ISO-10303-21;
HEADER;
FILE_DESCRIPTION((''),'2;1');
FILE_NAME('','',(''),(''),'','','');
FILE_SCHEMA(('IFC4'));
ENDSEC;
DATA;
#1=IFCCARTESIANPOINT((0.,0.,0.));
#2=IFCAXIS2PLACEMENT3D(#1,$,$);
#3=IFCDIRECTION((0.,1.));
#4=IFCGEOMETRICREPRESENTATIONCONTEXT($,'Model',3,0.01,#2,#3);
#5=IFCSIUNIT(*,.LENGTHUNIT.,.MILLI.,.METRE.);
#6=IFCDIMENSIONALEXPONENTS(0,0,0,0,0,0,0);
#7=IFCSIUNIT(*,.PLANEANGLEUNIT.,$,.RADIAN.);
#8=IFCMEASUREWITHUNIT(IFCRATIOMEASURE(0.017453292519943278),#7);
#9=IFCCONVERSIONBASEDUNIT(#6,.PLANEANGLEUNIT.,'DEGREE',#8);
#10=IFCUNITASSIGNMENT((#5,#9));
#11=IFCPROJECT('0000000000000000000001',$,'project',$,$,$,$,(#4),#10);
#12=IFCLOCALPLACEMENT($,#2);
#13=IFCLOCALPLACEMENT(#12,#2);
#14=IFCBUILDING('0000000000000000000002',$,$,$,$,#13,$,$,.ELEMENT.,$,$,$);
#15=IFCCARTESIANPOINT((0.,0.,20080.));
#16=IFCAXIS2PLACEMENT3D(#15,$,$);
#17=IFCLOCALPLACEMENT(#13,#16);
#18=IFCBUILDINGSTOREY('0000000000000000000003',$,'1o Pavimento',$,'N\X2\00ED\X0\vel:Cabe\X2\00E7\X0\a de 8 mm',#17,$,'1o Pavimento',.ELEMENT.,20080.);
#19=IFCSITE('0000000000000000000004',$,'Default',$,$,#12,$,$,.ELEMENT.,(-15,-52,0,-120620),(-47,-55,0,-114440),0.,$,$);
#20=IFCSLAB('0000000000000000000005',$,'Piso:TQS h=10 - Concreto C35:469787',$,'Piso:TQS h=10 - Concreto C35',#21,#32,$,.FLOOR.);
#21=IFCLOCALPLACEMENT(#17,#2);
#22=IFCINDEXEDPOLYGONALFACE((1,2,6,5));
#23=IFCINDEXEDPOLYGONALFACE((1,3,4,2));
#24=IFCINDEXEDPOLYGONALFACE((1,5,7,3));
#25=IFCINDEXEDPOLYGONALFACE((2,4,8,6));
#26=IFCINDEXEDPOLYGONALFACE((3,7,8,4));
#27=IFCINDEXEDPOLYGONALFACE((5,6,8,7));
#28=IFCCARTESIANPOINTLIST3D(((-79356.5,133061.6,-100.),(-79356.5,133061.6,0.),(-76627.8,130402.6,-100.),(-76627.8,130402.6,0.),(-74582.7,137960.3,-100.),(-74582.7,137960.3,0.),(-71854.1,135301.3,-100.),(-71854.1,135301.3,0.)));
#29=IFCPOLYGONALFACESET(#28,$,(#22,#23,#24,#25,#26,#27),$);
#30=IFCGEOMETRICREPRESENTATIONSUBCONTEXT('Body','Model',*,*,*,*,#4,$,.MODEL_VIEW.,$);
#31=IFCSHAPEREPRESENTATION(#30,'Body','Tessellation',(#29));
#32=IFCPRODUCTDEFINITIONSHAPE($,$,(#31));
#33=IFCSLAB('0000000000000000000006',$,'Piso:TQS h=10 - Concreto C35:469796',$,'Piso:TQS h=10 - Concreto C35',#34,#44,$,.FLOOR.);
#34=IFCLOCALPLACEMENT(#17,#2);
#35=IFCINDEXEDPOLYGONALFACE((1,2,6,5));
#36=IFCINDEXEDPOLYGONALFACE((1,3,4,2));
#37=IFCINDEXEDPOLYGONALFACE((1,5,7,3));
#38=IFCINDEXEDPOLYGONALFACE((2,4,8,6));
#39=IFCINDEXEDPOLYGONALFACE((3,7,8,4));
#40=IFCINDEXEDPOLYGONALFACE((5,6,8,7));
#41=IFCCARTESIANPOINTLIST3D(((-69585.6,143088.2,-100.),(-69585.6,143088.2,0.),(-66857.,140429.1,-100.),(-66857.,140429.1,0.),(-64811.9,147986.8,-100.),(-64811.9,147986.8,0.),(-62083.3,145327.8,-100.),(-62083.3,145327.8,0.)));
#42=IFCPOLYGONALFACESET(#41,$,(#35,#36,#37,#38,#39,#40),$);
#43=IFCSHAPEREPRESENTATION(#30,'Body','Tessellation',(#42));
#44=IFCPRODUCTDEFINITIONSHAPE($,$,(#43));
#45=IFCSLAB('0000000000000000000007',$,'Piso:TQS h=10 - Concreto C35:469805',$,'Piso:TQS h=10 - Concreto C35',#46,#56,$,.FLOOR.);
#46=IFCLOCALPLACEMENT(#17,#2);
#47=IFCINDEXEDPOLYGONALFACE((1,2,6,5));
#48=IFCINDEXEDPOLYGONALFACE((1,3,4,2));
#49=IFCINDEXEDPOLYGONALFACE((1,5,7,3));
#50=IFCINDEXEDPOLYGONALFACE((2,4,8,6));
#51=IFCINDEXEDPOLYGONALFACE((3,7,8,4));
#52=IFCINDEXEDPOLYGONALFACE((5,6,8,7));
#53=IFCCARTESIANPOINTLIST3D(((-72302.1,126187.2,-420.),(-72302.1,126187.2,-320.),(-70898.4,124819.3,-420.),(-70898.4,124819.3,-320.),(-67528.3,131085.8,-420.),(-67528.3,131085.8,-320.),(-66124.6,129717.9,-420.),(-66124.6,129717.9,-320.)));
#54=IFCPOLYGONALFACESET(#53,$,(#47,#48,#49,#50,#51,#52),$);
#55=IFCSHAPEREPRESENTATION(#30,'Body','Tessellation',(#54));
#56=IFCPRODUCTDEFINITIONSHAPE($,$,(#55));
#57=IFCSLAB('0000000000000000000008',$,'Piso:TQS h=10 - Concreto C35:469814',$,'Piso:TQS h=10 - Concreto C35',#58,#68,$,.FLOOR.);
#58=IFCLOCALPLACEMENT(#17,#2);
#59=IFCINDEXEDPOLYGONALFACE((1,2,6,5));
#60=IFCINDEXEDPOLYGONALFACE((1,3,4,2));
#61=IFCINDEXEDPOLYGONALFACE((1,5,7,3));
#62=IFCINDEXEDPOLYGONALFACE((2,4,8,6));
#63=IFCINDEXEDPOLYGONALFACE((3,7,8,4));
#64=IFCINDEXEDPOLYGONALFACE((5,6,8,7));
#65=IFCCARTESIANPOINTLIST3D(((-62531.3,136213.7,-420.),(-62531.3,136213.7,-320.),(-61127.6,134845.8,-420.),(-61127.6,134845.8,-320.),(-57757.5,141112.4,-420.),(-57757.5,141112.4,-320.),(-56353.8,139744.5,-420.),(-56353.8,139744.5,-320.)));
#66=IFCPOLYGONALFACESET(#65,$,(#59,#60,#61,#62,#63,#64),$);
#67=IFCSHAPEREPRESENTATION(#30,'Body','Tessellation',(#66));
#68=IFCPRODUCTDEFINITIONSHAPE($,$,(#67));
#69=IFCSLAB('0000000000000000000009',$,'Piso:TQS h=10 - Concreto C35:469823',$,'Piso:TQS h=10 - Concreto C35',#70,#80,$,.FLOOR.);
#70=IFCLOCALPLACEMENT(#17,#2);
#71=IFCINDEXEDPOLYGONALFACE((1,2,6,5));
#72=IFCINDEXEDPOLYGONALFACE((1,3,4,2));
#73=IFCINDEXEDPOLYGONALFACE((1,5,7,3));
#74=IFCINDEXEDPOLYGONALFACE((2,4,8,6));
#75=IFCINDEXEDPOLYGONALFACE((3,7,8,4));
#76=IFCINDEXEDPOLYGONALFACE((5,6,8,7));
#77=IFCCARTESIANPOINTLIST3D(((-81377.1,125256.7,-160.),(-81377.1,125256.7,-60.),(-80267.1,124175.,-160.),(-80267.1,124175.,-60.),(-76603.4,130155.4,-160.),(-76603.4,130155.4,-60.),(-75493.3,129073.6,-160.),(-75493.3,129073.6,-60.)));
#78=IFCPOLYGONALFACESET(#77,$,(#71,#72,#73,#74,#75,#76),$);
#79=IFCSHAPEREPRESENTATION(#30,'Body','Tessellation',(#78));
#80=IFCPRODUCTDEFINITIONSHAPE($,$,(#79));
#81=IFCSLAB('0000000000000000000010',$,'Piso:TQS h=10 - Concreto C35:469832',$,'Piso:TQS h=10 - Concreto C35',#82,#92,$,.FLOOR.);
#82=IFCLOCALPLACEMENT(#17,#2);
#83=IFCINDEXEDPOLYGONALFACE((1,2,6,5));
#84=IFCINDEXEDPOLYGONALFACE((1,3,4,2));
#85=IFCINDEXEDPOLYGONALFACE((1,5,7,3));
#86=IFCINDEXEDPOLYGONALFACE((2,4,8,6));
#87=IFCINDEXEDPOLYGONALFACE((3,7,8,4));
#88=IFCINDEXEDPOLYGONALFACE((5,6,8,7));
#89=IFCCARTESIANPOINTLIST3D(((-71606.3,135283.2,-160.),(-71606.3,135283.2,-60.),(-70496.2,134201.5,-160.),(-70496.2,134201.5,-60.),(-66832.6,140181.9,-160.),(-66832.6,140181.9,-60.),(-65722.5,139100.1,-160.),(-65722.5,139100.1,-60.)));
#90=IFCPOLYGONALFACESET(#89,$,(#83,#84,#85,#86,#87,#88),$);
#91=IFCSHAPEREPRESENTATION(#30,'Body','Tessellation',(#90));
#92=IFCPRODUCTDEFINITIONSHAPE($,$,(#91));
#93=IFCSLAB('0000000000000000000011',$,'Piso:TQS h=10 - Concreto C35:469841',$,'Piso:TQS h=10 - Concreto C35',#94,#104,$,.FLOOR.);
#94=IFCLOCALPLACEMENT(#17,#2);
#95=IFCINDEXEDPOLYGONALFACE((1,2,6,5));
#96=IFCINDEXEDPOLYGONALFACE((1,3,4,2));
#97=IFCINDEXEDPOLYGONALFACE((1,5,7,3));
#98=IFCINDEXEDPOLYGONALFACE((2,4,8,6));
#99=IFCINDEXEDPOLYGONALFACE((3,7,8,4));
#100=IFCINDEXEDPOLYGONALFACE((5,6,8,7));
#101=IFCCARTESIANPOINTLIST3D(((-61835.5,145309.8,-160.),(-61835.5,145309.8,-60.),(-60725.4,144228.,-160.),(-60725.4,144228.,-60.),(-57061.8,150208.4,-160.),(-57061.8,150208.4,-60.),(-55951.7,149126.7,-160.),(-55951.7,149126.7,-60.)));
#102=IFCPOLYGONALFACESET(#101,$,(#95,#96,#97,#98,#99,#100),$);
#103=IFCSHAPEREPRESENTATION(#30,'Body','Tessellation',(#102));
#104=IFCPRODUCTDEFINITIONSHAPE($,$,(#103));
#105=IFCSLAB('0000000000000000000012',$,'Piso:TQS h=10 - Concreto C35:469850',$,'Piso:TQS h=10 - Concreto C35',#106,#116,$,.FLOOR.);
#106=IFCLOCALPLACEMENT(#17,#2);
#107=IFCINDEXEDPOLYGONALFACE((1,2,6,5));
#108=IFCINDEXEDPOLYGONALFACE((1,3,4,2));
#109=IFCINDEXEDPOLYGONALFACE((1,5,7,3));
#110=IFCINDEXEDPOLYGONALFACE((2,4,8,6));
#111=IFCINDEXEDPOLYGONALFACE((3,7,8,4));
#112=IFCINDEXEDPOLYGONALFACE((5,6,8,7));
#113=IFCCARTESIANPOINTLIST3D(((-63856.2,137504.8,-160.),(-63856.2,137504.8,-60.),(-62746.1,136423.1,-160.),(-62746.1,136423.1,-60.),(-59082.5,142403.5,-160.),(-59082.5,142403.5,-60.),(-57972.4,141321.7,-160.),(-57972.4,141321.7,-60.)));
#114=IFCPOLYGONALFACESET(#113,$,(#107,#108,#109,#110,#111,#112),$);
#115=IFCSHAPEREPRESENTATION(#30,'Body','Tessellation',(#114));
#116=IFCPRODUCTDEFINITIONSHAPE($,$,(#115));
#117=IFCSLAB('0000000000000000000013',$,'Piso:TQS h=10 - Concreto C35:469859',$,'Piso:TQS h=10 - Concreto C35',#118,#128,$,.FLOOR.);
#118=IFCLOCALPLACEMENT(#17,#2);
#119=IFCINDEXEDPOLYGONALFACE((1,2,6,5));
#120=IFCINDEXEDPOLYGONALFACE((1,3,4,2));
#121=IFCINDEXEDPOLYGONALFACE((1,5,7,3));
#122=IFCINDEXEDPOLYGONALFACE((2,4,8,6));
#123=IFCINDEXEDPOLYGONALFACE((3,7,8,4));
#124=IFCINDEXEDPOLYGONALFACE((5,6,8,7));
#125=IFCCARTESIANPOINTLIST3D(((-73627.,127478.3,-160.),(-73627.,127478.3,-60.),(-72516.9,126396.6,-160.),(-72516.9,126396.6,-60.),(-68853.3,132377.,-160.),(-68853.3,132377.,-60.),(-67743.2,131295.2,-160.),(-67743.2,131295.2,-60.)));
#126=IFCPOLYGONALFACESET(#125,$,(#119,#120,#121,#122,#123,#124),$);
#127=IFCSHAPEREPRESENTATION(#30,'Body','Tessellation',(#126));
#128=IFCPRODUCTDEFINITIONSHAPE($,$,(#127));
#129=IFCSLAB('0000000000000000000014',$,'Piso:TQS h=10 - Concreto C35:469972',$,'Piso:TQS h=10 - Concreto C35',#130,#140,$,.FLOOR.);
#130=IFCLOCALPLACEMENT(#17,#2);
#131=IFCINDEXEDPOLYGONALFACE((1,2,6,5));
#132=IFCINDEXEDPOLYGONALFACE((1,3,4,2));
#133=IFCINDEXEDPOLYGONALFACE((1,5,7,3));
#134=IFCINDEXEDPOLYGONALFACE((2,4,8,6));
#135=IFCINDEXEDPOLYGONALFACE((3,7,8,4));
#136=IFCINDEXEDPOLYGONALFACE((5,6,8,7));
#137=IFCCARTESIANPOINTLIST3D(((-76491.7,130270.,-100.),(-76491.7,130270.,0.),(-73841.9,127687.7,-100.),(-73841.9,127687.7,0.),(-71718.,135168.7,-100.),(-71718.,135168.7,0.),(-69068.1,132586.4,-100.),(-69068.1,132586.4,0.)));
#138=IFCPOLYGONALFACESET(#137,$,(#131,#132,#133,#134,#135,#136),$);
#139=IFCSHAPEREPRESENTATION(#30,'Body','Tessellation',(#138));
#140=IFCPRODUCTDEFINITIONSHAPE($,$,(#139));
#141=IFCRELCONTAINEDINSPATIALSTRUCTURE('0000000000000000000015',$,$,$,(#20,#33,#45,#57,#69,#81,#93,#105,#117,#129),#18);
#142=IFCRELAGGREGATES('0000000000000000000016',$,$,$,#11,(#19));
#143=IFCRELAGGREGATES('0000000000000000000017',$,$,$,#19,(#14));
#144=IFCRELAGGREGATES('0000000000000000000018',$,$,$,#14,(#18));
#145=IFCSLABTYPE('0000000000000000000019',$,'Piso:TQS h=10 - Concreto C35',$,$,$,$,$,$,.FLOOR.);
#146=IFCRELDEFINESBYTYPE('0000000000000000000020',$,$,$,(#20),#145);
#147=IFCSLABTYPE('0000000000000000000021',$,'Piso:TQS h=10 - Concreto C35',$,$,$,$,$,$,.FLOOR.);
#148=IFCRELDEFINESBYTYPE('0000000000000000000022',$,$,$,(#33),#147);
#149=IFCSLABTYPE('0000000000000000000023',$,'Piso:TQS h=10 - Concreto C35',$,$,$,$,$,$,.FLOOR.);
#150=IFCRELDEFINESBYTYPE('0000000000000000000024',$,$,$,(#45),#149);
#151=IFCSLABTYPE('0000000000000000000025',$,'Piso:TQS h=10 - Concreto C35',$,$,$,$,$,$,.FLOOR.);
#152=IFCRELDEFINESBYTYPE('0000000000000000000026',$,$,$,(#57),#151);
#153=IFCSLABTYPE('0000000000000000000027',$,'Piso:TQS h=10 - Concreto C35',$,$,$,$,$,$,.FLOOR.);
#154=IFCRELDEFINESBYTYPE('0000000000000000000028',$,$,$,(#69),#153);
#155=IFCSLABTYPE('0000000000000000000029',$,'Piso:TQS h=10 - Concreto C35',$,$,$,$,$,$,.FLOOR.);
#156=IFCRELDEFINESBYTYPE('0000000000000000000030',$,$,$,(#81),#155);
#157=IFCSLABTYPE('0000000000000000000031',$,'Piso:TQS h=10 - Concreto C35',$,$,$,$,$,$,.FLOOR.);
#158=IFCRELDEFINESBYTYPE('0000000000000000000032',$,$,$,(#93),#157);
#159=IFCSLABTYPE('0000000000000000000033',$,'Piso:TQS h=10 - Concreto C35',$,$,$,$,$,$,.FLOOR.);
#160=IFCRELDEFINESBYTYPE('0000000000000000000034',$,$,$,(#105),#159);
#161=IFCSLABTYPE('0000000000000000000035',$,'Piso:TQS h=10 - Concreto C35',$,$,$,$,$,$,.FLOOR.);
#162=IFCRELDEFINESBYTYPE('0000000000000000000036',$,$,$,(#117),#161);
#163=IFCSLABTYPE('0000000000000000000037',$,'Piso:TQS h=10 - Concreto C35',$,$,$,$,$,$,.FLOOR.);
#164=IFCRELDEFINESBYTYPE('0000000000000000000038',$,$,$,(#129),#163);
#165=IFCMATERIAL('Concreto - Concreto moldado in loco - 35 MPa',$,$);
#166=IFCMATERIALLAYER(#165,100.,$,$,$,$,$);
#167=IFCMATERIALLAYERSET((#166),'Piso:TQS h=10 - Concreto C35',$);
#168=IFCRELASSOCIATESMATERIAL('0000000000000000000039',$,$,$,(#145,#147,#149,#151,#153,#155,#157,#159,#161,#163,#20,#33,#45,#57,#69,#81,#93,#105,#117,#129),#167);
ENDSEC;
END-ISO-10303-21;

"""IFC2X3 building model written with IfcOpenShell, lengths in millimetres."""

from ifc_helpers import new_model, entity, si_unit, converted_unit, direction, frame, frame_2d, origin, place, context, subcontext, project, spatial, polyline, rectangle, outline, extrude, material, layer, layer_set, layer_usage, type_object, element, save


model = new_model("IFC2X3")

# Units and contexts
model_context = context("Model", 3, precision=0.01, world=origin(), true_north=direction((0.0, 1.0)))
body_context = subcontext(model_context, "Body", "Model", "MODEL_VIEW")
ifc_project = project(units=[si_unit("LENGTHUNIT", "METRE", prefix="MILLI"), converted_unit("PLANEANGLEUNIT", "DEGREE", entity("IfcRatioMeasure", 0.017453292519943278), si_unit("PLANEANGLEUNIT", "RADIAN"), dimensions=[0, 0, 0, 0, 0, 0, 0])], contexts=[model_context])

# Site, building, storey
site_placement = place(None, origin())
site = spatial("IfcSite", under=ifc_project, at=site_placement, Name="Default", CompositionType="ELEMENT", RefLatitude=(-15, -52, 0, -120620), RefLongitude=(-47, -55, 0, -114440), RefElevation=0.0)
building_placement = place(site_placement, origin())
building = spatial("IfcBuilding", under=site, at=building_placement, CompositionType="ELEMENT")
storey_placement = place(building_placement, frame((0.0, 0.0, 20080.0)))
storey = spatial("IfcBuildingStorey", under=building, at=storey_placement, Name="1o Pavimento", ObjectType="Nível:Cabeça de 8 mm", LongName="1o Pavimento", CompositionType="ELEMENT", Elevation=20080.0)

# Shared definitions
ifc_material = material(Name="Concreto - Concreto moldado in loco - 35 MPa")

# Slabs
ifc_layer = layer(ifc_material, 100.0)
ifc_layer_set = layer_set([ifc_layer], Name="Piso:TQS h=10 - Concreto C35")
ifc_layer_usage_1 = layer_usage(ifc_layer_set, "AXIS3", "POSITIVE", 0.0)
slab_type_1 = type_object("IfcSlabType", Name="Piso:TQS h=10 - Concreto C35", PredefinedType="FLOOR", material=ifc_layer_set)
slab_1_placement = place(storey_placement, origin())
element("IfcSlab", 1, at=slab_1_placement, inside=storey, type_object=slab_type_1, material=ifc_layer_usage_1, Name="Piso:TQS h=10 - Concreto C35:469787", ObjectType="Piso:TQS h=10 - Concreto C35", PredefinedType="FLOOR", context=body_context, shape_type="SweptSolid", body=[
    extrude(rectangle(XDim=6840.0, YDim=3810.0, at=frame_2d((0.0, 0.0), x_axis=(1.0, 0.0))), frame((-75605.3, 134181.5, 0.0), z_axis=(0.0, 0.0, -1.0), x_axis=(-0.697915, -0.71618, 0.0)), (0.0, 0.0, 1.0), 100.0),
])
ifc_layer_usage_2 = layer_usage(ifc_layer_set, "AXIS3", "POSITIVE", 0.0)
slab_type_2 = type_object("IfcSlabType", Name="Piso:TQS h=10 - Concreto C35", PredefinedType="FLOOR", material=ifc_layer_set)
slab_2_placement = place(storey_placement, origin())
element("IfcSlab", 2, at=slab_2_placement, inside=storey, type_object=slab_type_2, material=ifc_layer_usage_2, Name="Piso:TQS h=10 - Concreto C35:469796", ObjectType="Piso:TQS h=10 - Concreto C35", PredefinedType="FLOOR", context=body_context, shape_type="SweptSolid", body=[
    extrude(rectangle(XDim=3810.0, YDim=6840.0, at=frame_2d((0.0, 0.0), x_axis=(1.0, 0.0))), frame((-65834.4, 144208.0, 0.0), z_axis=(0.0, 0.0, -1.0), x_axis=(0.71618, -0.697915, 0.0)), (0.0, 0.0, 1.0), 100.0),
])
ifc_layer_usage_3 = layer_usage(ifc_layer_set, "AXIS3", "POSITIVE", 0.0)
slab_type_3 = type_object("IfcSlabType", Name="Piso:TQS h=10 - Concreto C35", PredefinedType="FLOOR", material=ifc_layer_set)
slab_3_placement = place(storey_placement, origin())
element("IfcSlab", 3, at=slab_3_placement, inside=storey, type_object=slab_type_3, material=ifc_layer_usage_3, Name="Piso:TQS h=10 - Concreto C35:469805", ObjectType="Piso:TQS h=10 - Concreto C35", PredefinedType="FLOOR", context=body_context, shape_type="SweptSolid", body=[
    extrude(rectangle(XDim=6840.0, YDim=1960.0, at=frame_2d((0.0, 0.0), x_axis=(1.0, 0.0))), frame((-69213.4, 127952.6, -320.0), z_axis=(0.0, 0.0, -1.0), x_axis=(-0.697915, -0.71618, 0.0)), (0.0, 0.0, 1.0), 100.0),
])
ifc_layer_usage_4 = layer_usage(ifc_layer_set, "AXIS3", "POSITIVE", 0.0)
slab_type_4 = type_object("IfcSlabType", Name="Piso:TQS h=10 - Concreto C35", PredefinedType="FLOOR", material=ifc_layer_set)
slab_4_placement = place(storey_placement, origin())
element("IfcSlab", 4, at=slab_4_placement, inside=storey, type_object=slab_type_4, material=ifc_layer_usage_4, Name="Piso:TQS h=10 - Concreto C35:469814", ObjectType="Piso:TQS h=10 - Concreto C35", PredefinedType="FLOOR", context=body_context, shape_type="SweptSolid", body=[
    extrude(rectangle(XDim=1960.0, YDim=6840.0, at=frame_2d((0.0, 0.0), x_axis=(1.0, 0.0))), frame((-59442.5, 137979.1, -320.0), z_axis=(0.0, 0.0, -1.0), x_axis=(0.71618, -0.697915, 0.0)), (0.0, 0.0, 1.0), 100.0),
])
ifc_layer_usage_5 = layer_usage(ifc_layer_set, "AXIS3", "POSITIVE", 0.0)
slab_type_5 = type_object("IfcSlabType", Name="Piso:TQS h=10 - Concreto C35", PredefinedType="FLOOR", material=ifc_layer_set)
slab_5_placement = place(storey_placement, origin())
element("IfcSlab", 5, at=slab_5_placement, inside=storey, type_object=slab_type_5, material=ifc_layer_usage_5, Name="Piso:TQS h=10 - Concreto C35:469823", ObjectType="Piso:TQS h=10 - Concreto C35", PredefinedType="FLOOR", context=body_context, shape_type="SweptSolid", body=[
    extrude(rectangle(XDim=6840.0, YDim=1550.0, at=frame_2d((0.0, 0.0), x_axis=(1.0, 0.0))), frame((-78435.2, 127165.2, -60.0), z_axis=(0.0, 0.0, -1.0), x_axis=(-0.697915, -0.71618, 0.0)), (0.0, 0.0, 1.0), 100.0),
])
ifc_layer_usage_6 = layer_usage(ifc_layer_set, "AXIS3", "POSITIVE", 0.0)
slab_type_6 = type_object("IfcSlabType", Name="Piso:TQS h=10 - Concreto C35", PredefinedType="FLOOR", material=ifc_layer_set)
slab_6_placement = place(storey_placement, origin())
element("IfcSlab", 6, at=slab_6_placement, inside=storey, type_object=slab_type_6, material=ifc_layer_usage_6, Name="Piso:TQS h=10 - Concreto C35:469832", ObjectType="Piso:TQS h=10 - Concreto C35", PredefinedType="FLOOR", context=body_context, shape_type="SweptSolid", body=[
    extrude(rectangle(XDim=6840.0, YDim=1550.0, at=frame_2d((0.0, 0.0), x_axis=(1.0, 0.0))), frame((-68664.4, 137191.7, -60.0), z_axis=(0.0, 0.0, -1.0), x_axis=(-0.697915, -0.71618, 0.0)), (0.0, 0.0, 1.0), 100.0),
])
ifc_layer_usage_7 = layer_usage(ifc_layer_set, "AXIS3", "POSITIVE", 0.0)
slab_type_7 = type_object("IfcSlabType", Name="Piso:TQS h=10 - Concreto C35", PredefinedType="FLOOR", material=ifc_layer_set)
slab_7_placement = place(storey_placement, origin())
element("IfcSlab", 7, at=slab_7_placement, inside=storey, type_object=slab_type_7, material=ifc_layer_usage_7, Name="Piso:TQS h=10 - Concreto C35:469841", ObjectType="Piso:TQS h=10 - Concreto C35", PredefinedType="FLOOR", context=body_context, shape_type="SweptSolid", body=[
    extrude(outline(polyline([(-3420.0, -775.0), (3420.0, -775.0), (3420.0, 775.0), (-3420.0, 775.0), (-3420.0, -775.0)])), frame((-58893.6, 147218.2, -60.0), z_axis=(0.0, 0.0, -1.0), x_axis=(-0.69791, -0.716186, 0.0)), (0.0, 0.0, 1.0), 100.0),
])
ifc_layer_usage_8 = layer_usage(ifc_layer_set, "AXIS3", "POSITIVE", 0.0)
slab_type_8 = type_object("IfcSlabType", Name="Piso:TQS h=10 - Concreto C35", PredefinedType="FLOOR", material=ifc_layer_set)
slab_8_placement = place(storey_placement, origin())
element("IfcSlab", 8, at=slab_8_placement, inside=storey, type_object=slab_type_8, material=ifc_layer_usage_8, Name="Piso:TQS h=10 - Concreto C35:469850", ObjectType="Piso:TQS h=10 - Concreto C35", PredefinedType="FLOOR", context=body_context, shape_type="SweptSolid", body=[
    extrude(rectangle(XDim=1550.0, YDim=6840.0, at=frame_2d((0.0, 0.0), x_axis=(1.0, 0.0))), frame((-60914.3, 139413.3, -60.0), z_axis=(0.0, 0.0, -1.0), x_axis=(0.71618, -0.697915, 0.0)), (0.0, 0.0, 1.0), 100.0),
])
ifc_layer_usage_9 = layer_usage(ifc_layer_set, "AXIS3", "POSITIVE", 0.0)
slab_type_9 = type_object("IfcSlabType", Name="Piso:TQS h=10 - Concreto C35", PredefinedType="FLOOR", material=ifc_layer_set)
slab_9_placement = place(storey_placement, origin())
element("IfcSlab", 9, at=slab_9_placement, inside=storey, type_object=slab_type_9, material=ifc_layer_usage_9, Name="Piso:TQS h=10 - Concreto C35:469859", ObjectType="Piso:TQS h=10 - Concreto C35", PredefinedType="FLOOR", context=body_context, shape_type="SweptSolid", body=[
    extrude(rectangle(XDim=6840.0, YDim=1550.0, at=frame_2d((0.0, 0.0), x_axis=(1.0, 0.0))), frame((-70685.1, 129386.8, -60.0), z_axis=(0.0, 0.0, -1.0), x_axis=(-0.697915, -0.71618, 0.0)), (0.0, 0.0, 1.0), 100.0),
])
ifc_layer_usage_10 = layer_usage(ifc_layer_set, "AXIS3", "POSITIVE", 0.0)
slab_type_10 = type_object("IfcSlabType", Name="Piso:TQS h=10 - Concreto C35", PredefinedType="FLOOR", material=ifc_layer_set)
slab_10_placement = place(storey_placement, origin())
element("IfcSlab", 10, at=slab_10_placement, inside=storey, type_object=slab_type_10, material=ifc_layer_usage_10, Name="Piso:TQS h=10 - Concreto C35:469972", ObjectType="Piso:TQS h=10 - Concreto C35", PredefinedType="FLOOR", context=body_context, shape_type="SweptSolid", body=[
    extrude(rectangle(XDim=6840.0, YDim=3700.0, at=frame_2d((0.0, 0.0), x_axis=(1.0, 0.0))), frame((-72779.9, 131428.2, 0.0), z_axis=(0.0, 0.0, -1.0), x_axis=(-0.697915, -0.71618, 0.0)), (0.0, 0.0, 1.0), 100.0),
])

save(model, "model.ifc")
